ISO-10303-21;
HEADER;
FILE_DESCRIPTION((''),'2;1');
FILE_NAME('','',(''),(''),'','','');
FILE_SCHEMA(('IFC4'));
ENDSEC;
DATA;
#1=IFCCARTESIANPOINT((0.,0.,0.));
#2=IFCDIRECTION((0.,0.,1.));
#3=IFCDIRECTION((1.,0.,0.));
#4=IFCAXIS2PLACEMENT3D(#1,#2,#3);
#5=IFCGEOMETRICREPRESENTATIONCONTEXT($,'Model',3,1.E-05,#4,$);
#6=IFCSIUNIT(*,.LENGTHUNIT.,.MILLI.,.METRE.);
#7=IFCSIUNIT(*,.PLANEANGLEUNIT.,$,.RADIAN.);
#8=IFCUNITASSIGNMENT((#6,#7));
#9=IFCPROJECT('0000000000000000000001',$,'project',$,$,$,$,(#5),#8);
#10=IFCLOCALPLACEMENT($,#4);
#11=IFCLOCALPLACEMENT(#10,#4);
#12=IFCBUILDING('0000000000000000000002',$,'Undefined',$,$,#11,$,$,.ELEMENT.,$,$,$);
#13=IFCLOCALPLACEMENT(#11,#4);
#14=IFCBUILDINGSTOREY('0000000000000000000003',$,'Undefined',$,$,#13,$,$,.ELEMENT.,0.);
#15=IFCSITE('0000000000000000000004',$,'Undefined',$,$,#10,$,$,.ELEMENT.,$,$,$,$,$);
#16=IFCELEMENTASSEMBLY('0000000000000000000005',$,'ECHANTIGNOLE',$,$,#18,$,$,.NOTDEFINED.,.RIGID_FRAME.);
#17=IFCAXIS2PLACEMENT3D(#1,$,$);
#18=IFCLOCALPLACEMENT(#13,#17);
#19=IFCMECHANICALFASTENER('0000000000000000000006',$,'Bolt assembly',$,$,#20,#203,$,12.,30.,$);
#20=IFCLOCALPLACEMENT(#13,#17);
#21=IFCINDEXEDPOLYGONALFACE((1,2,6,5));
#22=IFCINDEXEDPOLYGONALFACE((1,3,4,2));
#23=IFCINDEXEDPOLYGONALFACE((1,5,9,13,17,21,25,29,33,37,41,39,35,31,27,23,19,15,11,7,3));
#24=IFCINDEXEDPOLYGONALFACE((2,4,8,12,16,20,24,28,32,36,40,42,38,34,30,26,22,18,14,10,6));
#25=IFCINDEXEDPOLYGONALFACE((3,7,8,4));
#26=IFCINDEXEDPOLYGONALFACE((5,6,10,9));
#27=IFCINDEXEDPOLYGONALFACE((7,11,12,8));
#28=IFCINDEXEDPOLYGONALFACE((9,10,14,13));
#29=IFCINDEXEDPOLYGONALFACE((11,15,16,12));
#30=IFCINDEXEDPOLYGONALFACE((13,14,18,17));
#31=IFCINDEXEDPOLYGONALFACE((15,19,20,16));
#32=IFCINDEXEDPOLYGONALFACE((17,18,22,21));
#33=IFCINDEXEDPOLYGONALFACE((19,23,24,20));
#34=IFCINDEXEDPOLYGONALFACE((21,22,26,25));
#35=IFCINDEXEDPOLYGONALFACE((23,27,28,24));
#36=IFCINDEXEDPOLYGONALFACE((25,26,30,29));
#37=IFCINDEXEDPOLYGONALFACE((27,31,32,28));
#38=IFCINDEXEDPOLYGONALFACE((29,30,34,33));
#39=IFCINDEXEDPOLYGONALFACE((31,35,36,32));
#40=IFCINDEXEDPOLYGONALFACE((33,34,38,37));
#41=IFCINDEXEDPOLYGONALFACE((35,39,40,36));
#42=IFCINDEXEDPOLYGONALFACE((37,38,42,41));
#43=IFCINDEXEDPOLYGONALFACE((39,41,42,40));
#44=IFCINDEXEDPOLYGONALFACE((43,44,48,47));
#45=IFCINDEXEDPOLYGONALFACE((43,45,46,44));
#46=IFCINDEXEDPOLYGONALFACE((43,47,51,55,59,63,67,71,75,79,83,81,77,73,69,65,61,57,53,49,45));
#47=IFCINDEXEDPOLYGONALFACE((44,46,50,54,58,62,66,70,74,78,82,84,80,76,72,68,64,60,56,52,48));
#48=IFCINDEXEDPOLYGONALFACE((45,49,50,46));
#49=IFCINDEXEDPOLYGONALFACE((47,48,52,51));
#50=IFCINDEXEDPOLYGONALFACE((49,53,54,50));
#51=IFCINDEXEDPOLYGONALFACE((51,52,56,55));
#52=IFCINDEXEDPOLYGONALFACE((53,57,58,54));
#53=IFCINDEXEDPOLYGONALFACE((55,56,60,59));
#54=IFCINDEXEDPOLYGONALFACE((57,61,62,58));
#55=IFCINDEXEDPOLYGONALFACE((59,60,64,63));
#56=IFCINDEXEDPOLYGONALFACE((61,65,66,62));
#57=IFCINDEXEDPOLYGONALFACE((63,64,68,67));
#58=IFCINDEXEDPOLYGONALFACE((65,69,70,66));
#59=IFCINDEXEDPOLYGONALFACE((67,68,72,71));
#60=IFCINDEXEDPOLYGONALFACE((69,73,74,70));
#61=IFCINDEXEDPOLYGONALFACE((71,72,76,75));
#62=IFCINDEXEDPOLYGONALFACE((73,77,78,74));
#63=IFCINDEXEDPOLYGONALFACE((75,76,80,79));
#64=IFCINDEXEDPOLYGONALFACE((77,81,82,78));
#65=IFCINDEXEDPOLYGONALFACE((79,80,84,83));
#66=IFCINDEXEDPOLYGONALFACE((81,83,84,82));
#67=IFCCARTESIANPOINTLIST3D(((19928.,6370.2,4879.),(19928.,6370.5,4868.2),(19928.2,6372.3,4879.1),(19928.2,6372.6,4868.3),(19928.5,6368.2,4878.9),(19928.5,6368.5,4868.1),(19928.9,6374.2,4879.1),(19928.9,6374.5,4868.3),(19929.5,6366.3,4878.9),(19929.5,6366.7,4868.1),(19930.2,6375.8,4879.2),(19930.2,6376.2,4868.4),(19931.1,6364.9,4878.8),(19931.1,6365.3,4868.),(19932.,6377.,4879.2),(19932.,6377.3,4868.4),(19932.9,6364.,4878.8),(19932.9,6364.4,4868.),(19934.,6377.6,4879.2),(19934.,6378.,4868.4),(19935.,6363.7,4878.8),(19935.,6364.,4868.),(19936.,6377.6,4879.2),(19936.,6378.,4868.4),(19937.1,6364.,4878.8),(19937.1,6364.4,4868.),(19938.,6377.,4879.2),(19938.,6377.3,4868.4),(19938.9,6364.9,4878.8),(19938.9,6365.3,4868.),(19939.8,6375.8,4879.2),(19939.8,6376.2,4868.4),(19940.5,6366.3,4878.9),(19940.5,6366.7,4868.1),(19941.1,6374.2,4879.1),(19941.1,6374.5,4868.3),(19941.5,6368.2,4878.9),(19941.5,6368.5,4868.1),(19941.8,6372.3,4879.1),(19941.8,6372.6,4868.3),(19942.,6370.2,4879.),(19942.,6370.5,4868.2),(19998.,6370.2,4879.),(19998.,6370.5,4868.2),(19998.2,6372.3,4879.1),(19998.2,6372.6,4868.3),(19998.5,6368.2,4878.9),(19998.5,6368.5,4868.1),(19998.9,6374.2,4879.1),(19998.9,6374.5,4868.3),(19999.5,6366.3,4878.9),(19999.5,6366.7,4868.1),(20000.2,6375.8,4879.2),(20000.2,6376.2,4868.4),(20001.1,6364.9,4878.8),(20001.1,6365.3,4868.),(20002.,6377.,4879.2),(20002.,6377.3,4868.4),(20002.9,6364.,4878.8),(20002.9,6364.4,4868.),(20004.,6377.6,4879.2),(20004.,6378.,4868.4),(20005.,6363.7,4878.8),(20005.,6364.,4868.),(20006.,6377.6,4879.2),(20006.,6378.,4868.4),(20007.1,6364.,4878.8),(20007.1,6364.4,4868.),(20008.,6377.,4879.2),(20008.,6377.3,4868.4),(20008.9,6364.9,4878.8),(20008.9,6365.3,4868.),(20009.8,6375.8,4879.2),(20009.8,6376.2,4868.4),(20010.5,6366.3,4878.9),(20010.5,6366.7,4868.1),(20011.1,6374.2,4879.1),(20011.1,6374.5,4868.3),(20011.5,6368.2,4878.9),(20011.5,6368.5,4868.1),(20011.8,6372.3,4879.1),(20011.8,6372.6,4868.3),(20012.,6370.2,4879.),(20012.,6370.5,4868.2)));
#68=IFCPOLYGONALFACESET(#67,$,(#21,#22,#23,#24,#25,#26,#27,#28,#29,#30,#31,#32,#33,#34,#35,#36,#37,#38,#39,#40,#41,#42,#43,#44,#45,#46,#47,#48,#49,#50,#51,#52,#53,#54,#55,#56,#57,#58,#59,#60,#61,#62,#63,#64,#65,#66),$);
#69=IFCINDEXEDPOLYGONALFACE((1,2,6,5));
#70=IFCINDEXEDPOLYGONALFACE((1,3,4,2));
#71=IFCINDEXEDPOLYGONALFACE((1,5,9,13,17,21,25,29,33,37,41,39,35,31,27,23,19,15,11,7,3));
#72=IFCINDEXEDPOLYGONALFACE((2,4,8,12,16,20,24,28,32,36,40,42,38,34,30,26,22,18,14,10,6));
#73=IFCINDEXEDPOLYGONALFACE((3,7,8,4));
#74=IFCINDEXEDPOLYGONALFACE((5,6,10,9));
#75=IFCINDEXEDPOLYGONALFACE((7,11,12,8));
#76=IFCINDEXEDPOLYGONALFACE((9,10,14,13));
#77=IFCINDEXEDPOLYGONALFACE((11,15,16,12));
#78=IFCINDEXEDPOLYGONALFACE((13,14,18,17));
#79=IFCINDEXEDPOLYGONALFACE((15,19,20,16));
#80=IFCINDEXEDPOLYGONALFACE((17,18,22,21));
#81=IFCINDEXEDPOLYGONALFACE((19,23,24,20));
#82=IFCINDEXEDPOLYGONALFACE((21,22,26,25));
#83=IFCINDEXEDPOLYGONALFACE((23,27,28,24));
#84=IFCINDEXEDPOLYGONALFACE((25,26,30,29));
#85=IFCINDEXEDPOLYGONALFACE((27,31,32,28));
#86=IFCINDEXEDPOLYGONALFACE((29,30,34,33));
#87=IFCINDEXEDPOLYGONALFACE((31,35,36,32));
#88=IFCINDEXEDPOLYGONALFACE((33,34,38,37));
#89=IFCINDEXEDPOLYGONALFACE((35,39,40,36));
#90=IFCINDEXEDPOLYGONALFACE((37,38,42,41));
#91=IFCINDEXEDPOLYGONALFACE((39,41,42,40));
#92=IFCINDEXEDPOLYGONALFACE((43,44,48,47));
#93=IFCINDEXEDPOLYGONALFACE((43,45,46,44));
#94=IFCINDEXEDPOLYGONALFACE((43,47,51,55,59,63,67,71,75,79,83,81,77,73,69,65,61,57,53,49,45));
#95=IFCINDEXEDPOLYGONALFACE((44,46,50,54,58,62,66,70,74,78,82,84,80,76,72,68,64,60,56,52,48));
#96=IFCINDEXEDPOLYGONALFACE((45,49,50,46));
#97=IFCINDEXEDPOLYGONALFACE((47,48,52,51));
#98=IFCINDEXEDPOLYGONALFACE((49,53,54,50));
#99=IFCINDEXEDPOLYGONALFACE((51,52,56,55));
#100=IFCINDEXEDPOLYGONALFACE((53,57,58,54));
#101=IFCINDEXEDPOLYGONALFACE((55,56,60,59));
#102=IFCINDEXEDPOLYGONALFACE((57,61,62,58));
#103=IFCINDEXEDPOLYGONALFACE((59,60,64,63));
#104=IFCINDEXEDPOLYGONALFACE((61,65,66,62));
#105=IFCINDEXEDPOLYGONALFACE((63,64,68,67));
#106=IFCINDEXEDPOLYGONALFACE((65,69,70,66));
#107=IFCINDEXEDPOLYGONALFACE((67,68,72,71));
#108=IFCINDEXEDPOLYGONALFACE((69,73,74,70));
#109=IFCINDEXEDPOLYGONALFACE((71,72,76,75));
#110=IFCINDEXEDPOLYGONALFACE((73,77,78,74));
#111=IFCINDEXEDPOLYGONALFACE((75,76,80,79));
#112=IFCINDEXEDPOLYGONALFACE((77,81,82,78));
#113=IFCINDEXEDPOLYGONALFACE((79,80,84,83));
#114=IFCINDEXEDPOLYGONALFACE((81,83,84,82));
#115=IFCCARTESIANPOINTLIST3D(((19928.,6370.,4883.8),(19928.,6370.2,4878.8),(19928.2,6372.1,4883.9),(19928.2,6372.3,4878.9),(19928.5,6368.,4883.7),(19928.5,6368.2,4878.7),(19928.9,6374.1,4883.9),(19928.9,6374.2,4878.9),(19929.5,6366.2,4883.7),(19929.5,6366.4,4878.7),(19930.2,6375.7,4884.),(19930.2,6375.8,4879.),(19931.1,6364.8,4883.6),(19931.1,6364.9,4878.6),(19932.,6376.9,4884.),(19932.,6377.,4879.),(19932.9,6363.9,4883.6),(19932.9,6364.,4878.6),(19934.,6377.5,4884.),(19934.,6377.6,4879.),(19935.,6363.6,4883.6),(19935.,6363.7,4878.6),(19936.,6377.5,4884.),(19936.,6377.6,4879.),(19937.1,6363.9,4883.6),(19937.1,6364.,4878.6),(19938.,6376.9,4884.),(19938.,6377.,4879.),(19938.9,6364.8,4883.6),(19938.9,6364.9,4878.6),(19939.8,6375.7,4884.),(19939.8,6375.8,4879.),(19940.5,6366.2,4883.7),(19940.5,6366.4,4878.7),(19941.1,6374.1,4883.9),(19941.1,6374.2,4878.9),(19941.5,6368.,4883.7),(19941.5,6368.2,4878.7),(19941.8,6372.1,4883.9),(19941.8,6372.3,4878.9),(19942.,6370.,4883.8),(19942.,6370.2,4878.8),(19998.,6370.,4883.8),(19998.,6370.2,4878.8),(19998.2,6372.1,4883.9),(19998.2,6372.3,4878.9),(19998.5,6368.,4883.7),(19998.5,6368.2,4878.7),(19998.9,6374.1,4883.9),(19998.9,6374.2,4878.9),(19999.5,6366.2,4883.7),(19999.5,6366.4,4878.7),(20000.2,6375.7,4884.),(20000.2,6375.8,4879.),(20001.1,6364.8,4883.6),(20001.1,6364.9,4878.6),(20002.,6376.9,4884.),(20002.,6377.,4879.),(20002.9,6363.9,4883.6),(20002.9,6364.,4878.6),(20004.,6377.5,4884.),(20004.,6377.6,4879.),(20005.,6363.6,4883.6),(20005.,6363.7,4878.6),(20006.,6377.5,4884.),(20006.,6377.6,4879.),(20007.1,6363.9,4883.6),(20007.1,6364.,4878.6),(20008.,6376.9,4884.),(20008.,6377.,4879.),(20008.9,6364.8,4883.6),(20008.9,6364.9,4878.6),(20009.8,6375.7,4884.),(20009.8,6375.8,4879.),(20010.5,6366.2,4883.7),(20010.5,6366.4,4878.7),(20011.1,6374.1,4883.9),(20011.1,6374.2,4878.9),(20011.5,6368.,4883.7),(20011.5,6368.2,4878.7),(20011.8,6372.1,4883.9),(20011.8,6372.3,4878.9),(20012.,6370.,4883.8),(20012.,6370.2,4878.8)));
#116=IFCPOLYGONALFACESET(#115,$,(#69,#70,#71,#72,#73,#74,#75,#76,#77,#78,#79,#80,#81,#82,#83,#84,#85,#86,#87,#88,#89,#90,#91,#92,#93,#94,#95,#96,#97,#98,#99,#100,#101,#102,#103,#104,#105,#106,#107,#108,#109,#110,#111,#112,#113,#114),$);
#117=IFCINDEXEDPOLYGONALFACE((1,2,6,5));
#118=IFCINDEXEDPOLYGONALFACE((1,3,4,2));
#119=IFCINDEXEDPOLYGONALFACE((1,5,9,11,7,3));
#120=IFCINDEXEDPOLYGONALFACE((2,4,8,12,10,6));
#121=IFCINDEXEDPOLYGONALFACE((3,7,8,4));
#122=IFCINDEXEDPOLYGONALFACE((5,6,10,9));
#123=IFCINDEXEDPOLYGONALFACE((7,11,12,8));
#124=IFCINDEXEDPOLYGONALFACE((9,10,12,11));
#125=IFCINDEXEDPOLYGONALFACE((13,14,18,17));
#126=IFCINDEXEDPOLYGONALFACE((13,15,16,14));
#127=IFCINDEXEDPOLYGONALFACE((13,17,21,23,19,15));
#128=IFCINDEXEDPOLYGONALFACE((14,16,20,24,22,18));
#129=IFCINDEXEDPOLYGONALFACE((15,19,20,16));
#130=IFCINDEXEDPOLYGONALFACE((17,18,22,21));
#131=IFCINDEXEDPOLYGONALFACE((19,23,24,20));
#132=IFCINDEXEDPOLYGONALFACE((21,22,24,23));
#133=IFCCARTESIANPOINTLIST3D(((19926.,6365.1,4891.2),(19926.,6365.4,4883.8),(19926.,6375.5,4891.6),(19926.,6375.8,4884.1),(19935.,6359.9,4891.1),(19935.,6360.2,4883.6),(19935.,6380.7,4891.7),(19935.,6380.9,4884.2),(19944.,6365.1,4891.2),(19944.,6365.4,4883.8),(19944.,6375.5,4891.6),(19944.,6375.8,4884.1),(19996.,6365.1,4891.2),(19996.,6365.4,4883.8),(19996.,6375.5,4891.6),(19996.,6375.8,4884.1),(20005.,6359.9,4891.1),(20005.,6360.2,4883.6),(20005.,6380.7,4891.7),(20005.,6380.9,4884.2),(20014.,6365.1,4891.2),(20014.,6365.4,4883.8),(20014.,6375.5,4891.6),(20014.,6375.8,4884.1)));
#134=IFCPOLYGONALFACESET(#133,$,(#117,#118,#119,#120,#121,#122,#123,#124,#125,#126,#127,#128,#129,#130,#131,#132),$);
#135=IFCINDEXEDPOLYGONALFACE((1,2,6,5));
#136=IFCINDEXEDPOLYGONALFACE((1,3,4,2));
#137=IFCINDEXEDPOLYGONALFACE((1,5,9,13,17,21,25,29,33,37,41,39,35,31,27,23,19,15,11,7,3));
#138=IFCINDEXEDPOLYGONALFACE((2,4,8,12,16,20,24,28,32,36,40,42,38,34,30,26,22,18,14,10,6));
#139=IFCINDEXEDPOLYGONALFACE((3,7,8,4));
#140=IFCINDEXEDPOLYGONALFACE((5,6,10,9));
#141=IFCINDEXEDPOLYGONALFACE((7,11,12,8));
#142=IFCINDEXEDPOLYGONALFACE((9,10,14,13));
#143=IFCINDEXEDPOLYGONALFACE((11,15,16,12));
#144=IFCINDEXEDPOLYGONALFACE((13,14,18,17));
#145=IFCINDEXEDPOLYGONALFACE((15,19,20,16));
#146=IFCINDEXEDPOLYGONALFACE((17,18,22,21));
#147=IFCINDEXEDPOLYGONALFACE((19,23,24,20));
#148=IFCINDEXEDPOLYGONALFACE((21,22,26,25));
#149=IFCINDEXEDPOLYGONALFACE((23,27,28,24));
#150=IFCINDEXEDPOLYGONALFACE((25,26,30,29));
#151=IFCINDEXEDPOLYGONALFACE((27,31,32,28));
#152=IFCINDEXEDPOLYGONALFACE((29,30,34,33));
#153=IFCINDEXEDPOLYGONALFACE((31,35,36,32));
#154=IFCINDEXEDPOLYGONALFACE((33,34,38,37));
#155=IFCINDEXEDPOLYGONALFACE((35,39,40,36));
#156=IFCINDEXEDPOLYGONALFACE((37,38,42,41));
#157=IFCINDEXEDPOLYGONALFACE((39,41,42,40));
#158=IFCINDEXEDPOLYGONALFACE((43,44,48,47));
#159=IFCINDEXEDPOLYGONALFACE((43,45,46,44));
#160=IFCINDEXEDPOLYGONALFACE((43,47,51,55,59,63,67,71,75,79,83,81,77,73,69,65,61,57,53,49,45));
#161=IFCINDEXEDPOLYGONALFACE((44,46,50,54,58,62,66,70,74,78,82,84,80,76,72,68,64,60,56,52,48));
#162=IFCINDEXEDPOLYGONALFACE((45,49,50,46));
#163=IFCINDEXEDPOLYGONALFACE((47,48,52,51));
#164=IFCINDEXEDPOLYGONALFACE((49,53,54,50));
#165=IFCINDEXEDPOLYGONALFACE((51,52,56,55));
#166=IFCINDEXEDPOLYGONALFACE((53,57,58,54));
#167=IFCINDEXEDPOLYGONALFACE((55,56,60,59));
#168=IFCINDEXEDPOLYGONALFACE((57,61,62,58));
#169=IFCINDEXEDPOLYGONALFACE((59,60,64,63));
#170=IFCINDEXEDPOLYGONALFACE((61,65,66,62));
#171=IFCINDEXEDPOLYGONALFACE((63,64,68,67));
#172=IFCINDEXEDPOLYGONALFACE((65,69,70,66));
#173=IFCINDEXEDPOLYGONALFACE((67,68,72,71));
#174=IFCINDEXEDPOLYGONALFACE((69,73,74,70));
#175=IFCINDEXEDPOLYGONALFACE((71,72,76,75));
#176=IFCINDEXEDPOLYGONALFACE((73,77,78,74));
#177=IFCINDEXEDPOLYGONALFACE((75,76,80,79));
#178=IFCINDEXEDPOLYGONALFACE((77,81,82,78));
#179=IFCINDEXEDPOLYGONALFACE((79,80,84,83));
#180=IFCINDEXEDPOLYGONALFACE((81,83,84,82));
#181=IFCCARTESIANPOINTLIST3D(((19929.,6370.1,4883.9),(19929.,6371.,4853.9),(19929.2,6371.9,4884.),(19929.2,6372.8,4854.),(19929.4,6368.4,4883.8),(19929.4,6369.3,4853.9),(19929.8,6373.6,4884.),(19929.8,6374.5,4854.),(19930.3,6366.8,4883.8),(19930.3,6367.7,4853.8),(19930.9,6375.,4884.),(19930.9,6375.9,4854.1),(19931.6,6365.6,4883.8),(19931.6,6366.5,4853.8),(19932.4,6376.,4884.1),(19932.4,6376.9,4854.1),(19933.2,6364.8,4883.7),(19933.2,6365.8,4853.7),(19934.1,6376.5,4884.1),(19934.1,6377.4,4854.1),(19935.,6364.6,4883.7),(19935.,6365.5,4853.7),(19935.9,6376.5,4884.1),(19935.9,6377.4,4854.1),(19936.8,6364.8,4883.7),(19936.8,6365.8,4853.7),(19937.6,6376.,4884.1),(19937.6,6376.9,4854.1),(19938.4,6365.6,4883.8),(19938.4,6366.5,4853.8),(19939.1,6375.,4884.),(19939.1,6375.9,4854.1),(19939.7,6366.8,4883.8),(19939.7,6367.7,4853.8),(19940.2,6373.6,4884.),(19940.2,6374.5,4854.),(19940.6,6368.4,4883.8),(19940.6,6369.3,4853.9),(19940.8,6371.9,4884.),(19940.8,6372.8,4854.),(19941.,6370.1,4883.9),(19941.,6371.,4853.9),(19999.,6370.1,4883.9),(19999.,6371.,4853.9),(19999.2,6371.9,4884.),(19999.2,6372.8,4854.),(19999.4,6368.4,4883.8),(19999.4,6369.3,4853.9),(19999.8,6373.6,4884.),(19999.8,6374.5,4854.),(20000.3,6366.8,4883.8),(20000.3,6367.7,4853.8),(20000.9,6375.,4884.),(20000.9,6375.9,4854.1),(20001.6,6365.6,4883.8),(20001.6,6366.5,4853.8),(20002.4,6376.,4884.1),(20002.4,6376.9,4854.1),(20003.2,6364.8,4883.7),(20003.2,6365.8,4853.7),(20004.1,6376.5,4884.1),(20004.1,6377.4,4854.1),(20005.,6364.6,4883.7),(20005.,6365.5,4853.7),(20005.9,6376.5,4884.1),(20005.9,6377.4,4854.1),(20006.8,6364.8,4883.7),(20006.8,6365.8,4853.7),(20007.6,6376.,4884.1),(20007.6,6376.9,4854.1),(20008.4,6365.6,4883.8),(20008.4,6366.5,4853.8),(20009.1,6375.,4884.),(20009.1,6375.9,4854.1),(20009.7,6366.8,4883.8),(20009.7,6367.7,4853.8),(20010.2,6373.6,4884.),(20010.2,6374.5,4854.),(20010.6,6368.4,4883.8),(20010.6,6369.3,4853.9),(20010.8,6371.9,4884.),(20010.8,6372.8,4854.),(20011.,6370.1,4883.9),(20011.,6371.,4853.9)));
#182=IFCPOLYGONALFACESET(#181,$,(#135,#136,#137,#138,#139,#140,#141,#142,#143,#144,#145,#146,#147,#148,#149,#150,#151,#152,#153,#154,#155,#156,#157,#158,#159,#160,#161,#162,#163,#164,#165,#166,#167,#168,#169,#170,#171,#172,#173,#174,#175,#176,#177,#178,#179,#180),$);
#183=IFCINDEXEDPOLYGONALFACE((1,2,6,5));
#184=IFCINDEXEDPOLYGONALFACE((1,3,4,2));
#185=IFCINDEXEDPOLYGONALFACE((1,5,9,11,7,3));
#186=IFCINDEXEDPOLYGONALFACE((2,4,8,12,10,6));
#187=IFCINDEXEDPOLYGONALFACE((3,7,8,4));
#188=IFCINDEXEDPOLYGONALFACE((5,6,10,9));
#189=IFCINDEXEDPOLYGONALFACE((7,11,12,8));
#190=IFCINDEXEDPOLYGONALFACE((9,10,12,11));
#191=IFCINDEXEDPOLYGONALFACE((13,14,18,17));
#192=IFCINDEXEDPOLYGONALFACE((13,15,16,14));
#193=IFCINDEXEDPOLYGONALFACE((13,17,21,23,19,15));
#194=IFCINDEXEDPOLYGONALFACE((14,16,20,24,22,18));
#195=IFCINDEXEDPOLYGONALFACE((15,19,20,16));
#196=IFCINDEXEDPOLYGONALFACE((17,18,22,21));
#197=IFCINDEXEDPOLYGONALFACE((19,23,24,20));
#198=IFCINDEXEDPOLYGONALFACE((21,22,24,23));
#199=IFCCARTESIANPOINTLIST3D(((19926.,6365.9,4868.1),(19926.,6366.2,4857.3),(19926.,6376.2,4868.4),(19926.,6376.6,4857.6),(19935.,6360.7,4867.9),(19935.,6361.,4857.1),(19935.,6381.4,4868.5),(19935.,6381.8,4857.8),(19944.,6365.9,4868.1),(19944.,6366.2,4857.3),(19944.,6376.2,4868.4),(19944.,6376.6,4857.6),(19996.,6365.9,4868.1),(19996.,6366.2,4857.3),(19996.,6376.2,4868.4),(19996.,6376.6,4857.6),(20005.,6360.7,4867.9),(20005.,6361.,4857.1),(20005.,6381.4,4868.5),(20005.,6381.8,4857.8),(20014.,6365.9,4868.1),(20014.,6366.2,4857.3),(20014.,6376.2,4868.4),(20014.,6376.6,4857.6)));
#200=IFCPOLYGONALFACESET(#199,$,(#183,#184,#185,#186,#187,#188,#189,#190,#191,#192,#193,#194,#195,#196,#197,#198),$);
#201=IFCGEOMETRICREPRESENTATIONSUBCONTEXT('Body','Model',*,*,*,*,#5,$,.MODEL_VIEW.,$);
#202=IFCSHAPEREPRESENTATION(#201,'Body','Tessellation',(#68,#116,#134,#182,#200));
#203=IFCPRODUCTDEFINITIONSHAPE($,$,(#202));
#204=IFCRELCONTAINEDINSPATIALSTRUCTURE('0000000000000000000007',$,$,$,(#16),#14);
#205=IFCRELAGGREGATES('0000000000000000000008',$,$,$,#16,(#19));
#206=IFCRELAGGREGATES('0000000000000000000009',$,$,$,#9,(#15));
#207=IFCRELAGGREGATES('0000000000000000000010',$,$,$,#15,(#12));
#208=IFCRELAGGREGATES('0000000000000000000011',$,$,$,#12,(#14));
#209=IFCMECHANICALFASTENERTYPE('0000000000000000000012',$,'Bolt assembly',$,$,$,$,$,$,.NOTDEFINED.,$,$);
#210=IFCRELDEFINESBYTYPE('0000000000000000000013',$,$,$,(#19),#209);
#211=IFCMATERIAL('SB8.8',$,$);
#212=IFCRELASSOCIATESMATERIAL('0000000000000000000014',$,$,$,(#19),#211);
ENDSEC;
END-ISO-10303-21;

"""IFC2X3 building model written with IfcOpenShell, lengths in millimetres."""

from ifc_helpers import new_model, si_unit, frame, origin_with_axes, origin_2d_with_axis, place, context, subcontext, project, spatial, polyline, circle, outline, extrude, source, transform, mapped, material, type_object, element, aggregate, save


model = new_model("IFC2X3")

# Units and contexts
model_context = context("Model", 3, precision=1e-05, world=origin_with_axes())
body_context = subcontext(model_context, "Body", "Model", "MODEL_VIEW")
ifc_project = project(units=[si_unit("LENGTHUNIT", "METRE", prefix="MILLI"), si_unit("PLANEANGLEUNIT", "RADIAN")], contexts=[model_context])

# Site, building, storey
site_placement = place(None, origin_with_axes())
site = spatial("IfcSite", under=ifc_project, at=site_placement, Name="Undefined", CompositionType="ELEMENT")
building_placement = place(site_placement, origin_with_axes())
building = spatial("IfcBuilding", under=site, at=building_placement, Name="Undefined", CompositionType="ELEMENT")
storey_placement = place(building_placement, origin_with_axes())
storey = spatial("IfcBuildingStorey", under=building, at=storey_placement, Name="Undefined", CompositionType="ELEMENT", Elevation=0.0)

# Shared definitions
ifc_material_1 = material(Name="SB8.8")
mechanical_fastener_type = type_object("IfcMechanicalFastenerType", Name="Bolt assembly")

# Element assembly, mechanical fastener
shared_shape_1 = source(origin_with_axes(), body_context, "Body", "SweptSolid", [
    extrude(circle(Radius=7.0, at=origin_2d_with_axis()), frame((0.0, -0.1, 0.0), z_axis=(0.0, 1.0, 0.0), x_axis=(1.0, 0.0, 0.0)), (0.0, 0.0, 1.0), 10.8),
    extrude(circle(Radius=7.0, at=origin_2d_with_axis()), frame((0.0, -4.9, 0.0), z_axis=(0.0, 1.0, 0.0), x_axis=(1.0, 0.0, 0.0)), (0.0, 0.0, 1.0), 5.0),
    extrude(outline(polyline([(10.4, 0.0), (5.2, 9.0), (-5.2, 9.0), (-10.4, 0.0), (-5.2, -9.0), (5.2, -9.0), (10.4, 0.0)])), frame((0.0, -12.5, 0.0), z_axis=(0.0, 1.0, 0.0), x_axis=(1.0, 0.0, 0.0)), (0.0, 0.0, 1.0), 7.5),
    extrude(circle(Radius=6.0, at=origin_2d_with_axis()), frame((0.0, -5.0, 0.0), z_axis=(0.0, 1.0, 0.0), x_axis=(1.0, 0.0, 0.0)), (0.0, 0.0, 1.0), 30.0),
    extrude(outline(polyline([(10.4, 0.0), (5.2, 9.0), (-5.2, 9.0), (-10.4, 0.0), (-5.2, -9.0), (5.2, -9.0), (10.4, 0.0)])), frame((0.0, 10.7, 0.0), z_axis=(0.0, 1.0, 0.0), x_axis=(1.0, 0.0, 0.0)), (0.0, 0.0, 1.0), 10.8),
])
assembly_1_placement = place(storey_placement, origin_with_axes())
assembly_1 = element("IfcElementAssembly", 1, at=assembly_1_placement, inside=storey, Name="ECHANTIGNOLE", AssemblyPlace="NOTDEFINED", PredefinedType="RIGID_FRAME")
mechanical_fastener_1_placement = place(assembly_1_placement, frame((19970.0, 6370.7, 4878.9), z_axis=(1.0, 0.0, 0.0), x_axis=(0.0, -0.99952, -0.030986)))
mechanical_fastener_1 = element("IfcMechanicalFastener", 2, at=mechanical_fastener_1_placement, type_object=mechanical_fastener_type, material=ifc_material_1, Name="Bolt assembly", NominalDiameter=12.0, NominalLength=30.0, context=body_context, shape_type="MappedRepresentation", body=[
    mapped(shared_shape_1, transform((0.0, 0.0, -35.0))),
    mapped(shared_shape_1, transform((0.0, 0.0, 35.0))),
])
aggregate(assembly_1, [mechanical_fastener_1])

save(model, "model.ifc")
